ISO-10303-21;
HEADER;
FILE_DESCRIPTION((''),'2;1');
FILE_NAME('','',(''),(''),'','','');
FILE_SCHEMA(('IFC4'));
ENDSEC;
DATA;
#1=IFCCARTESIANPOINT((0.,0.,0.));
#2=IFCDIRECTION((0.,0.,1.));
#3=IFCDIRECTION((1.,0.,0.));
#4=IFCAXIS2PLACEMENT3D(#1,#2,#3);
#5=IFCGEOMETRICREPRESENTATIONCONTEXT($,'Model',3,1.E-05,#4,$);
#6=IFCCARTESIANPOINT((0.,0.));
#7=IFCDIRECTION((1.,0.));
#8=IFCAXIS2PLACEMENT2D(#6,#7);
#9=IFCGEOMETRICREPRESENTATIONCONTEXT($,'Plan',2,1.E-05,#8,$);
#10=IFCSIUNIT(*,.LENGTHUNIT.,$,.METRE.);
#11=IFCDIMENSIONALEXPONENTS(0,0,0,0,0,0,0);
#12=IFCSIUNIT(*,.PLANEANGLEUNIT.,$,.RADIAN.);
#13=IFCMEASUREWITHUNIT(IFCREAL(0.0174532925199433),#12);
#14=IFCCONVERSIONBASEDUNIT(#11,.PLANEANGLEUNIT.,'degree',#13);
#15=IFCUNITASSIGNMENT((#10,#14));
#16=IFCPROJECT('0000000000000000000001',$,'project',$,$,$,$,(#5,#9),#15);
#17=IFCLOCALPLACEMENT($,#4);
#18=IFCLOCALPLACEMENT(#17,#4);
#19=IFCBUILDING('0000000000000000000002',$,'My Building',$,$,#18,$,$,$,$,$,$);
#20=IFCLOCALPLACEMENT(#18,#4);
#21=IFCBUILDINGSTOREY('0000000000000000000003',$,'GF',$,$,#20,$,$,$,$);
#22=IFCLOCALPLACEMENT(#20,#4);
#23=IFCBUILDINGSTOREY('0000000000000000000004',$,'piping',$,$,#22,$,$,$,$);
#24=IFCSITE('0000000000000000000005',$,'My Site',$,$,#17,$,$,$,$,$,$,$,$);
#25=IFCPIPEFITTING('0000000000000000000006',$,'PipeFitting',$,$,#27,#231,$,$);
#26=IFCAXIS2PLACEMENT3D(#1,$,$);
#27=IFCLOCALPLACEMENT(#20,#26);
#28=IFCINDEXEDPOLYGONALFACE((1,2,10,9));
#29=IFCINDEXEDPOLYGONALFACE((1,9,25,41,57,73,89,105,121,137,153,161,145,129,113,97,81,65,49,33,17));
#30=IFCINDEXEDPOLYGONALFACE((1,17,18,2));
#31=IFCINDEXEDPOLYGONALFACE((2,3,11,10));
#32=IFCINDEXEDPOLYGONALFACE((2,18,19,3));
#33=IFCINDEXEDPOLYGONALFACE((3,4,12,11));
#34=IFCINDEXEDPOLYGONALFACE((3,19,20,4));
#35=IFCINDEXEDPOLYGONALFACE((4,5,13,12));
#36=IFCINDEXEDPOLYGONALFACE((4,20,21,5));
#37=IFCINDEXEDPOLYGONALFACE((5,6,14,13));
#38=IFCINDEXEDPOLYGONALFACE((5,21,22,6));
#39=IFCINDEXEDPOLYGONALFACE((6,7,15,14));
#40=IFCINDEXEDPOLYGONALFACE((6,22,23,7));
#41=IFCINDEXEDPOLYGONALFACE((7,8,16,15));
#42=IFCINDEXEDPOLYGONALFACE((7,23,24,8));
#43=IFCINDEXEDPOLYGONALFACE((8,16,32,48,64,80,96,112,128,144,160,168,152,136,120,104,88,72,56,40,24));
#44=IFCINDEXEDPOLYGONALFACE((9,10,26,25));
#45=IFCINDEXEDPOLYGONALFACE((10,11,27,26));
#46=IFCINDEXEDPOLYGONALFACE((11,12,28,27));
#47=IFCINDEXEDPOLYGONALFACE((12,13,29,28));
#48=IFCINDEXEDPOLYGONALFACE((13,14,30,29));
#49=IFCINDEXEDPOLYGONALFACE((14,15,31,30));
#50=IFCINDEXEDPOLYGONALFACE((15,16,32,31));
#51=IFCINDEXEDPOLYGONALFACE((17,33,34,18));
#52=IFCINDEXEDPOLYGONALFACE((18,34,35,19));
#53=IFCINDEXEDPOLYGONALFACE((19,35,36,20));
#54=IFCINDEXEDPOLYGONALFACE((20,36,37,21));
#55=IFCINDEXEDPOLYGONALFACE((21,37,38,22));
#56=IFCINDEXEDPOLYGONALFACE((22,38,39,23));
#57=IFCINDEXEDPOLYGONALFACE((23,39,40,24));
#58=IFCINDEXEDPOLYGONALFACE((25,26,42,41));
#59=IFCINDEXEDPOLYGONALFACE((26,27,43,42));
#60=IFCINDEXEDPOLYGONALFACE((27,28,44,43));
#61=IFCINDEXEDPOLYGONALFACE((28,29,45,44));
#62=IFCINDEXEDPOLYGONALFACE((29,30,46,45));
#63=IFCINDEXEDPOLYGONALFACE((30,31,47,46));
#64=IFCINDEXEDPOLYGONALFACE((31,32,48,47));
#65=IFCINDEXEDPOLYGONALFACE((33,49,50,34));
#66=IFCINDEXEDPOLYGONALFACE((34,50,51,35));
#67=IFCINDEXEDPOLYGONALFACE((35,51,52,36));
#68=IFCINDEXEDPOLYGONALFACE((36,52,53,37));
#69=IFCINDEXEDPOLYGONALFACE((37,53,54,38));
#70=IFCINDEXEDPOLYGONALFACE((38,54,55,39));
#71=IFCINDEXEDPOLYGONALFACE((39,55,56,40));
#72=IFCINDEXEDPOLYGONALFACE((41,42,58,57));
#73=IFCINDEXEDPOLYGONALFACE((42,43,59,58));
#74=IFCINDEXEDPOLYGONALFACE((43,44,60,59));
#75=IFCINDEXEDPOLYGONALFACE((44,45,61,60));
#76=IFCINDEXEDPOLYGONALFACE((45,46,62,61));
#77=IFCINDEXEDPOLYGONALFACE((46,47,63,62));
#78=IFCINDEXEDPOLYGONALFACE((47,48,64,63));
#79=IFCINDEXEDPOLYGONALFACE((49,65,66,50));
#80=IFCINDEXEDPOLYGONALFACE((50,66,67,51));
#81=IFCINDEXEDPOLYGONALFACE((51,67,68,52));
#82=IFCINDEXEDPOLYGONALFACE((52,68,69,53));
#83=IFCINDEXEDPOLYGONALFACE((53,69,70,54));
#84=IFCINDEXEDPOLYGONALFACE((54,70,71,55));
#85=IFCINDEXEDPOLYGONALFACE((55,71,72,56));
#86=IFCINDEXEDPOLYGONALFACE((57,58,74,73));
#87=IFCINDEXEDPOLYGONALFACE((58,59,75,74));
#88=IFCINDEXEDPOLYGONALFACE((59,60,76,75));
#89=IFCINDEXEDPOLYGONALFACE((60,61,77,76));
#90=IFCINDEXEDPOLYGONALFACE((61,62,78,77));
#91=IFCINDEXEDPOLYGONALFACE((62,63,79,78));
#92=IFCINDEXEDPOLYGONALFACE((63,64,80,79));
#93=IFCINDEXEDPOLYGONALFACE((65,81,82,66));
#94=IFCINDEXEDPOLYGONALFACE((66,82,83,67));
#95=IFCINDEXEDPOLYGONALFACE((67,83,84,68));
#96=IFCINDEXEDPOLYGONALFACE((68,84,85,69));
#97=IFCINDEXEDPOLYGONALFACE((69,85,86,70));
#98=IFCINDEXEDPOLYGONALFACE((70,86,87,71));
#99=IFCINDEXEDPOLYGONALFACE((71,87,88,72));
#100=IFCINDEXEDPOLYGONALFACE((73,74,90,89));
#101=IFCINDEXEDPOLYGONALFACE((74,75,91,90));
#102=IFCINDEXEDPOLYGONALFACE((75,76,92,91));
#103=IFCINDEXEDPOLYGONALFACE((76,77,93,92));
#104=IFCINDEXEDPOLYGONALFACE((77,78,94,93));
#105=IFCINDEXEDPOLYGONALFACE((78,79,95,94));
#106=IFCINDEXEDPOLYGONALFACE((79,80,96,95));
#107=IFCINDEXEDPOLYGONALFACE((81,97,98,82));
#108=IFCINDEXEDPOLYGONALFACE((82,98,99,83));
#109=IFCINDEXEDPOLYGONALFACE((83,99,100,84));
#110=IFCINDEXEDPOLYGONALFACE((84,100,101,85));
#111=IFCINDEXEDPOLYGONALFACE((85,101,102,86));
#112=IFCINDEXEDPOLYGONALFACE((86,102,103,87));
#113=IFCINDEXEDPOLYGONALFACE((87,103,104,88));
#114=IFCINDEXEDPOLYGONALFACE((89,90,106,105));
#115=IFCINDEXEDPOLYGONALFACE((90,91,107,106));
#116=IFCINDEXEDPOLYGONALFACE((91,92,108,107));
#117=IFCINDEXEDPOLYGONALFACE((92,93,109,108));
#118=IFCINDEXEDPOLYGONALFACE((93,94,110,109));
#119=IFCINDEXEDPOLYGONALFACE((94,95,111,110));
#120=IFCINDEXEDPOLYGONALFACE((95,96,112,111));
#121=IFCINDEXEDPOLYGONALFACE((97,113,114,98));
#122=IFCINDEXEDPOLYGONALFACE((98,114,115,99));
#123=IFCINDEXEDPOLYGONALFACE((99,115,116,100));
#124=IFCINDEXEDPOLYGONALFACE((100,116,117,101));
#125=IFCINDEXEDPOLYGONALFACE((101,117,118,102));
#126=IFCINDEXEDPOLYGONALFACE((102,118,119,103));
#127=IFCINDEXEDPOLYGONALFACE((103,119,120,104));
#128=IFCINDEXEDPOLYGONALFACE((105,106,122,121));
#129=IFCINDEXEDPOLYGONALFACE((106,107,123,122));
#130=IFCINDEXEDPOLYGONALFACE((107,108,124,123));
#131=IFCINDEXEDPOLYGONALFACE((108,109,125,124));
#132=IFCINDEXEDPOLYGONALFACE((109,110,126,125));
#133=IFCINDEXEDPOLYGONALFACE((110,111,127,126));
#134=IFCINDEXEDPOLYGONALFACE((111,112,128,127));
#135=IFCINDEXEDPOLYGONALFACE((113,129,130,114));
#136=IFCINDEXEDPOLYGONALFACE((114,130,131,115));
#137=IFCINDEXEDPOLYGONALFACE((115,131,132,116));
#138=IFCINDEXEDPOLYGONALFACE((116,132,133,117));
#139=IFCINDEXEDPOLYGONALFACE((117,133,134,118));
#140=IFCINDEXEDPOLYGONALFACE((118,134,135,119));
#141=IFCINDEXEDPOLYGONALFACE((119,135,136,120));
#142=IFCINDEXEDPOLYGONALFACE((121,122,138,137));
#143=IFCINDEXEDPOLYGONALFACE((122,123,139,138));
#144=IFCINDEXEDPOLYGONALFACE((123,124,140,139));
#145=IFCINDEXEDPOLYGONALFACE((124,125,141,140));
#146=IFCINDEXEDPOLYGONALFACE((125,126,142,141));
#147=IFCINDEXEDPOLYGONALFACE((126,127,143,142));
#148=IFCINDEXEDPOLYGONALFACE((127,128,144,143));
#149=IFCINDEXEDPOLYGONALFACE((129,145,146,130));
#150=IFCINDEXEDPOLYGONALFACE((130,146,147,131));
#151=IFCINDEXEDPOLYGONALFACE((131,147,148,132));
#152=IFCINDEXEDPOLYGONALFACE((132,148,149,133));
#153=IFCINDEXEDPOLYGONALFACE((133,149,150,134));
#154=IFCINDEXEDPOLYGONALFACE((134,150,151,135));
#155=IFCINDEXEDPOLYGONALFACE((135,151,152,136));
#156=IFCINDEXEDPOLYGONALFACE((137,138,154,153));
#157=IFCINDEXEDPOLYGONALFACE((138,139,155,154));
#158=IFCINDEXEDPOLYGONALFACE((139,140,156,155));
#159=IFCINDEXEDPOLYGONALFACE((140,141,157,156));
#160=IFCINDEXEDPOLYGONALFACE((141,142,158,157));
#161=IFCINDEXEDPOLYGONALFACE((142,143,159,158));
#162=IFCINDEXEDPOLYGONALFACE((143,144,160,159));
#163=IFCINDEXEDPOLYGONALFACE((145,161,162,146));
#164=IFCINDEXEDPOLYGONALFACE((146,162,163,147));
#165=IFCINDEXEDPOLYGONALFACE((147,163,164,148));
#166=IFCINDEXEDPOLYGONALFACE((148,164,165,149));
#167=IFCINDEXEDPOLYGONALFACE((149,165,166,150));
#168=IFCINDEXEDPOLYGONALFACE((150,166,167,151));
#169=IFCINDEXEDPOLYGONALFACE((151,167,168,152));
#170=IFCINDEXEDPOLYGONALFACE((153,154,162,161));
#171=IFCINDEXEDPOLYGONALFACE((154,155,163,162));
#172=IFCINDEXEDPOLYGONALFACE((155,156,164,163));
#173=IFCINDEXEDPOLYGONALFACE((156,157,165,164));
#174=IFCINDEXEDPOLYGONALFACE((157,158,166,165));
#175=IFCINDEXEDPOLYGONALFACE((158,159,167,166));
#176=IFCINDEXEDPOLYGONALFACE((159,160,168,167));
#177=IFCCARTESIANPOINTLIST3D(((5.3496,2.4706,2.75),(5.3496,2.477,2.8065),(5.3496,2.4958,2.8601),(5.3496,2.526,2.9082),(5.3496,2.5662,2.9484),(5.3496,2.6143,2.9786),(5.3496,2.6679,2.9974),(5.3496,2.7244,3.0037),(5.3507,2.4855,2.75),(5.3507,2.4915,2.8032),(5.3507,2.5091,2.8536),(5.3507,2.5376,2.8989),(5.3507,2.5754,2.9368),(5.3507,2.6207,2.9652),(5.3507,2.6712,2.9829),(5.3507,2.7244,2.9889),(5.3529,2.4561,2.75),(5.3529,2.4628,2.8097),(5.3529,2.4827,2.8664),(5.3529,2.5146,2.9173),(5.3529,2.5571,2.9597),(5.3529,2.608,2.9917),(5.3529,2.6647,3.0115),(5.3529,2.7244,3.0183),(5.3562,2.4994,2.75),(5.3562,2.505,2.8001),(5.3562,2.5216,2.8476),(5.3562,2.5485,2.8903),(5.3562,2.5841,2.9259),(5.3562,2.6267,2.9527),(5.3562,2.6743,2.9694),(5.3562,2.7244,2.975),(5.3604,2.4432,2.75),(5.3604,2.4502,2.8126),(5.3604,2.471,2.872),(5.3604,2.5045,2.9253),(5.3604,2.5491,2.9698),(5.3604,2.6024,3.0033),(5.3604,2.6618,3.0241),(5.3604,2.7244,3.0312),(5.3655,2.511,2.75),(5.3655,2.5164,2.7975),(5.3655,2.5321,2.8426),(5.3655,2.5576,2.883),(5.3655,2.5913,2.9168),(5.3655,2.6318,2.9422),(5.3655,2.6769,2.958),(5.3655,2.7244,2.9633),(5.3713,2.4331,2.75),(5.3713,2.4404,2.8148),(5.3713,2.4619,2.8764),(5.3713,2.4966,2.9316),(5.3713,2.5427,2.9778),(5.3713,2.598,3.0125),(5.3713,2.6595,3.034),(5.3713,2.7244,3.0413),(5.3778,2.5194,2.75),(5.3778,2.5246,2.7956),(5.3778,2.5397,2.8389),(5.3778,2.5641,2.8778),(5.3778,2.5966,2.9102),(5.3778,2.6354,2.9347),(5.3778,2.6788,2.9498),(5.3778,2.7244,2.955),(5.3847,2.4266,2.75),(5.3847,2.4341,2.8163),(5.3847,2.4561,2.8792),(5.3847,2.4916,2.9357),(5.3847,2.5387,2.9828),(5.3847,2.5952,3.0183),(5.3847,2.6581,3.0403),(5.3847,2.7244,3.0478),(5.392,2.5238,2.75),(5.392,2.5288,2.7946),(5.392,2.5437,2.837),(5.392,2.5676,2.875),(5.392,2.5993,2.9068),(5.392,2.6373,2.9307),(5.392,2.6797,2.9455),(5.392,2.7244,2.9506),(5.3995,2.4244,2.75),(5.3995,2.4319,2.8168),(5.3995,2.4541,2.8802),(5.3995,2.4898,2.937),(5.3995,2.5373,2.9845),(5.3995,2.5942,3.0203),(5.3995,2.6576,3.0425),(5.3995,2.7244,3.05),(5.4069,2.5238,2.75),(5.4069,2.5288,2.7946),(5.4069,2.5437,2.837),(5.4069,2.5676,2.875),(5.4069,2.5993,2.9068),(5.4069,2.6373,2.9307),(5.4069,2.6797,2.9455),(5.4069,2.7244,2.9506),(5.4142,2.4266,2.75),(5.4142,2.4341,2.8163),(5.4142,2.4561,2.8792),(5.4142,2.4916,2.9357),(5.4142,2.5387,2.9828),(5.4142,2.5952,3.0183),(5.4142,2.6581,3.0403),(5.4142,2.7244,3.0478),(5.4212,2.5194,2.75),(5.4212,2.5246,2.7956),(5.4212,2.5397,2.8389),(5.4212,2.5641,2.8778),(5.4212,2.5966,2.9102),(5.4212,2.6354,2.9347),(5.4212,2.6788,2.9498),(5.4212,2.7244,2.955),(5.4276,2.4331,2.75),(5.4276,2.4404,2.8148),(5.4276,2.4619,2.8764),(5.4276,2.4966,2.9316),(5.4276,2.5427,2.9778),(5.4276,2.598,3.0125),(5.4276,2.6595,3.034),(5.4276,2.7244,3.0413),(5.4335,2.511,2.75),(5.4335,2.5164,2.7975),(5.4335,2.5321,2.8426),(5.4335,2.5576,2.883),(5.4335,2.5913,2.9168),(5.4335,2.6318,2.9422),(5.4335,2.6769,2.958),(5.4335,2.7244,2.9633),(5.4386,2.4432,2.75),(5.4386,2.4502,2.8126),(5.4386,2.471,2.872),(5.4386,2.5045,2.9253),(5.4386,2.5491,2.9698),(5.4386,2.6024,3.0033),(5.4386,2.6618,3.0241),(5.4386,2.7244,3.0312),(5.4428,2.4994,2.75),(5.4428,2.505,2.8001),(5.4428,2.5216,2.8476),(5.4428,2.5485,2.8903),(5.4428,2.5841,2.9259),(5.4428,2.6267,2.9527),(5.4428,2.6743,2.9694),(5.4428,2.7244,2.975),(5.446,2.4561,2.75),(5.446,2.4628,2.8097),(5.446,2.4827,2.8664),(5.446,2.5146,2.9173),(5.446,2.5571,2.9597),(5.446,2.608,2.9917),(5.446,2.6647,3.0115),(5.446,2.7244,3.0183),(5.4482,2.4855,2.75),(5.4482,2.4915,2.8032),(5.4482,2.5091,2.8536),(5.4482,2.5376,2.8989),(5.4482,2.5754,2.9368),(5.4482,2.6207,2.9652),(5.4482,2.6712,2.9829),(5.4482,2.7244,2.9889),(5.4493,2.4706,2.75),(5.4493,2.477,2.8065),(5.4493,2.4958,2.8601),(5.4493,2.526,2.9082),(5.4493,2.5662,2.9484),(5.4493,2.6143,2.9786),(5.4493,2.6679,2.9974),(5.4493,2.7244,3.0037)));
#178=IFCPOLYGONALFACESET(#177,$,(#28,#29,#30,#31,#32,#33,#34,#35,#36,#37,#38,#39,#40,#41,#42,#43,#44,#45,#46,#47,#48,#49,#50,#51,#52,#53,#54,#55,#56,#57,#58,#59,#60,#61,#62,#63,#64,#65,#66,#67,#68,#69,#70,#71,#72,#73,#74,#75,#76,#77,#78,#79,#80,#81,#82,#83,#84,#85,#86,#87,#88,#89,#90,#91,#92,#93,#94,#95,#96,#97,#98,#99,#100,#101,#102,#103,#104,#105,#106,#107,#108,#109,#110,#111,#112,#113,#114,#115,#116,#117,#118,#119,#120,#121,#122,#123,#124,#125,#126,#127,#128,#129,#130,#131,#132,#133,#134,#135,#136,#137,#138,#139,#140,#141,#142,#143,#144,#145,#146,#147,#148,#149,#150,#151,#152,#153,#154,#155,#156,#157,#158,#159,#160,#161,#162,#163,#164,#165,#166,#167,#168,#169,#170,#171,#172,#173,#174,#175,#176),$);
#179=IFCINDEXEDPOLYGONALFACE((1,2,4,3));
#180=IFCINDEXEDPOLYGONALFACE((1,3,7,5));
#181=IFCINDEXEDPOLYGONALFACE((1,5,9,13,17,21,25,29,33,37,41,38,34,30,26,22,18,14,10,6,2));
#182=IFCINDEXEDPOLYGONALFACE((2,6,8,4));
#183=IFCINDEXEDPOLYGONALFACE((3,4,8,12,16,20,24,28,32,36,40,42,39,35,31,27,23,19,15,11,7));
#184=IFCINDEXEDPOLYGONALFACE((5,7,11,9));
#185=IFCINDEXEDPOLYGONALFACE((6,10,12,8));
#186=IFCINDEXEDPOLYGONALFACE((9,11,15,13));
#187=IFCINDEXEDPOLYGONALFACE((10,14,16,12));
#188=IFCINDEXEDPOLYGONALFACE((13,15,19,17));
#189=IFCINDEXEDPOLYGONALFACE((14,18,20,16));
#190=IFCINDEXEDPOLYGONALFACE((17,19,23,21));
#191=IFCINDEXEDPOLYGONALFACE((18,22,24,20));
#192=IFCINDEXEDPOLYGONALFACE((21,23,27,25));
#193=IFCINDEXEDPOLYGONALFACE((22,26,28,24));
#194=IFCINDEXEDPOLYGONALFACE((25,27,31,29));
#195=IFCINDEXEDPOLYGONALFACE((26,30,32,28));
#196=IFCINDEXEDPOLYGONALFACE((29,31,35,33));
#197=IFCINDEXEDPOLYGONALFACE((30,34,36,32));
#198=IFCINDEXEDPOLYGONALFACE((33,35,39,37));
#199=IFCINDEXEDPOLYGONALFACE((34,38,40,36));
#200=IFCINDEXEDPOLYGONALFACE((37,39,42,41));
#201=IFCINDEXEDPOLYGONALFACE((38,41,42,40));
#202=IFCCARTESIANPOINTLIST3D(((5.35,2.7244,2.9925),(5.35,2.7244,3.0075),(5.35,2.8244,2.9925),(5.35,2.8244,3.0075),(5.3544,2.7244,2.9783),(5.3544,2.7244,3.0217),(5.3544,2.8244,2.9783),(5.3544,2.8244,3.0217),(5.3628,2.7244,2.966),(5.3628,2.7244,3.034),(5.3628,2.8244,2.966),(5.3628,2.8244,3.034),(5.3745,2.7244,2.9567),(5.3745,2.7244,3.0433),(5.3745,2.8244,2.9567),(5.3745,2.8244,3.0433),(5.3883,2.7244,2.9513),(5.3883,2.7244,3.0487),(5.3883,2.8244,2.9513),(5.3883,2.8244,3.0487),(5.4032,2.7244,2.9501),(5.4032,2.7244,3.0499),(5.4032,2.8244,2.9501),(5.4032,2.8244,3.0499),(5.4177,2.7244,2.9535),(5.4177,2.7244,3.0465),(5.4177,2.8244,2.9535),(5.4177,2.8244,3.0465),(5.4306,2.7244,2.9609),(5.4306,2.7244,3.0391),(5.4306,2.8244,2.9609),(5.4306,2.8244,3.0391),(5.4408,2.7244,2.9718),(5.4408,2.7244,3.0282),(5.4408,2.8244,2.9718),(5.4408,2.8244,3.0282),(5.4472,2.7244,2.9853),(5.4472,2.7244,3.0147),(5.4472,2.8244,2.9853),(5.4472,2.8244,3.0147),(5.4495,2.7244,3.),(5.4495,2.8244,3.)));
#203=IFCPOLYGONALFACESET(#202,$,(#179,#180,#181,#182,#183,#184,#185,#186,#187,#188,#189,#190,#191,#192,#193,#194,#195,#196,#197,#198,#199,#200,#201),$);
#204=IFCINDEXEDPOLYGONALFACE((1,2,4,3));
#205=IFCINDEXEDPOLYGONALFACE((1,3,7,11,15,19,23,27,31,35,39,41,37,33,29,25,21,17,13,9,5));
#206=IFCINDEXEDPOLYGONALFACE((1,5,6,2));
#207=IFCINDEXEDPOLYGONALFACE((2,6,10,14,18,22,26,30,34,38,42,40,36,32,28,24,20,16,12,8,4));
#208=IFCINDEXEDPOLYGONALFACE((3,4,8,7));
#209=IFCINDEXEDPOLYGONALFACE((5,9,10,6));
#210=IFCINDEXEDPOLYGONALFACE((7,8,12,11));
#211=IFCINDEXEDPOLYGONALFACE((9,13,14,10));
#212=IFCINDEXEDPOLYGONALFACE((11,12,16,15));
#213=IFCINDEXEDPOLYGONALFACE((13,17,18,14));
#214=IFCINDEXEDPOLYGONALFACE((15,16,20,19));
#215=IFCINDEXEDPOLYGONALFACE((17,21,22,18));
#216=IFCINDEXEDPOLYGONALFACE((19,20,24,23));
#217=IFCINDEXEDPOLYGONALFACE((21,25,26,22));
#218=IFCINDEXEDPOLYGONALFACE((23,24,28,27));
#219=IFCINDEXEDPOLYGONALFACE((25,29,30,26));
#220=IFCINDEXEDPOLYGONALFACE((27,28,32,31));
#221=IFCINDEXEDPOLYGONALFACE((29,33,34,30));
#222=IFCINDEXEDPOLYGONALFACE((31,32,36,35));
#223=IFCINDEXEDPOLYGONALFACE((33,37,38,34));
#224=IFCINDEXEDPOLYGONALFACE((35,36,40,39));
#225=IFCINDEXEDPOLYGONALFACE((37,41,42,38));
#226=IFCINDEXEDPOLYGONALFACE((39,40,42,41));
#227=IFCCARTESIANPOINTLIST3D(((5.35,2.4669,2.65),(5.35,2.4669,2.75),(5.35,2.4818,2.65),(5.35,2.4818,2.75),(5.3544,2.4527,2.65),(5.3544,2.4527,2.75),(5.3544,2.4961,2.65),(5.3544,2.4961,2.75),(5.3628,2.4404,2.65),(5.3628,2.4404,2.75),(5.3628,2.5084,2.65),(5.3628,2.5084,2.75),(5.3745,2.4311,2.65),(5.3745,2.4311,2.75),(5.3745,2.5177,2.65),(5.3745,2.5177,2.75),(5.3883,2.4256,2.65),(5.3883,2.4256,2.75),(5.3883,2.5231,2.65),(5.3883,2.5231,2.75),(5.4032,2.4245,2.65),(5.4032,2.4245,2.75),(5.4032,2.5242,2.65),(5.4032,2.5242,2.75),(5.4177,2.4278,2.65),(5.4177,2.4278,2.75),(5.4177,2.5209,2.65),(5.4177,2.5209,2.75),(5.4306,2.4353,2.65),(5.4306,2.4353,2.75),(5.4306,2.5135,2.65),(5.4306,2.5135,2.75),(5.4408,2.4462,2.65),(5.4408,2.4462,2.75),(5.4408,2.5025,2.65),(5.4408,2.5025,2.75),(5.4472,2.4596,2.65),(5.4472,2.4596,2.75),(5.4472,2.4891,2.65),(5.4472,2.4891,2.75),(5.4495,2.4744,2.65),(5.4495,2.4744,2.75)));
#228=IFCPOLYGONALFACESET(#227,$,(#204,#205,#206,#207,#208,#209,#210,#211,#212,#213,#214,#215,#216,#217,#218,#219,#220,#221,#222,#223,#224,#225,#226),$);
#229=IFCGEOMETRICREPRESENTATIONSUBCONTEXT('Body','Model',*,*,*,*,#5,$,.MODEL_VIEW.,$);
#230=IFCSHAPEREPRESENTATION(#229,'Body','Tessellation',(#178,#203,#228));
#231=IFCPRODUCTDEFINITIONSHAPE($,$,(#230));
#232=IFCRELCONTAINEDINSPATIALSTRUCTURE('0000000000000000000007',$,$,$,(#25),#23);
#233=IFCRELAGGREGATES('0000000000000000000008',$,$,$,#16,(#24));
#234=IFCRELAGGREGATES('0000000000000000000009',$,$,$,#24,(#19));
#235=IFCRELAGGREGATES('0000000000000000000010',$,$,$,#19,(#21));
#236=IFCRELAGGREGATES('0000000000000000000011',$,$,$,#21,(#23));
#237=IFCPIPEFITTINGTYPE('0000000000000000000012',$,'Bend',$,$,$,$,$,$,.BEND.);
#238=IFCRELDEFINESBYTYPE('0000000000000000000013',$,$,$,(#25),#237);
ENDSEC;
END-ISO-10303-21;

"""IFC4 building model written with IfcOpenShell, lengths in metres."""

from ifc_helpers import new_model, entity, si_unit, converted_unit, frame, origin_with_axes, origin_2d_with_axis, place, context, subcontext, project, spatial, circle, extrude, source, transform, mapped, type_object, type_shapes, element, save


model = new_model("IFC4")

# Units and contexts
model_context = context("Model", 3, precision=1e-05, world=origin_with_axes())
plan_context = context("Plan", 2, precision=1e-05, world=origin_2d_with_axis())
body_context = subcontext(model_context, "Body", "Model", "MODEL_VIEW")
ifc_project = project(units=[si_unit("LENGTHUNIT", "METRE"), converted_unit("PLANEANGLEUNIT", "degree", entity("IfcReal", 0.0174532925199433), si_unit("PLANEANGLEUNIT", "RADIAN"), dimensions=[0, 0, 0, 0, 0, 0, 0])], contexts=[model_context, plan_context])

# Site, building, storeys
site_placement = place(None, origin_with_axes())
site = spatial("IfcSite", under=ifc_project, at=site_placement, Name="My Site")
building_placement = place(site_placement, origin_with_axes())
building = spatial("IfcBuilding", under=site, at=building_placement, Name="My Building")
storey_1_placement = place(building_placement, origin_with_axes())
storey_1 = spatial("IfcBuildingStorey", under=building, at=storey_1_placement, Name="GF")
storey_2_placement = place(storey_1_placement, origin_with_axes())
storey_2 = spatial("IfcBuildingStorey", under=storey_1, at=storey_2_placement, Name="piping")

# Pipe fitting
pipe_fitting_type = type_object("IfcPipeFittingType", Name="Bend", PredefinedType="BEND")
shared_shape = source(origin_with_axes(), body_context, "Body", "SolidModel", [
    entity("IfcSweptDiskSolid", entity("IfcIndexedPolyCurve", entity("IfcCartesianPointList3D", [[0.0, 0.0, 0.1], [0.0, -0.0732, 0.2768], [0.0, -0.25, 0.35]]), [entity("IfcArcIndex", [1, 2, 3])]), 0.05),
    extrude(circle(Radius=0.05), origin_with_axes(), (0.0, 0.0, 1.0), 0.1),
    extrude(circle(Radius=0.05), frame((0.0, -0.25, 0.35), z_axis=(0.0, -1.0, 0.0), x_axis=(1.0, 0.0, 0.0)), (0.0, 0.0, 1.0), 0.1),
])
type_shapes(pipe_fitting_type, [shared_shape])
for number, where, z_axis, x_axis, name in (
    (1, (5.3995, 2.8244, 3.0), (0.0, -1.0, 0.0), (1.0, 0.0, 0.0), "PipeFitting"),
):
    element("IfcPipeFitting", number, at=place(storey_2_placement, frame(where, z_axis=z_axis, x_axis=x_axis)), inside=storey_2, type_object=pipe_fitting_type, Name=name, context=body_context, shape_type="MappedRepresentation", body=[
        mapped(shared_shape, transform((0.0, 0.0, 0.0), x_axis=(1.0, 0.0, 0.0), y_axis=(0.0, 1.0, 0.0), z_axis=(0.0, 0.0, 1.0), scale=1.0)),
    ])

save(model, "model.ifc")
